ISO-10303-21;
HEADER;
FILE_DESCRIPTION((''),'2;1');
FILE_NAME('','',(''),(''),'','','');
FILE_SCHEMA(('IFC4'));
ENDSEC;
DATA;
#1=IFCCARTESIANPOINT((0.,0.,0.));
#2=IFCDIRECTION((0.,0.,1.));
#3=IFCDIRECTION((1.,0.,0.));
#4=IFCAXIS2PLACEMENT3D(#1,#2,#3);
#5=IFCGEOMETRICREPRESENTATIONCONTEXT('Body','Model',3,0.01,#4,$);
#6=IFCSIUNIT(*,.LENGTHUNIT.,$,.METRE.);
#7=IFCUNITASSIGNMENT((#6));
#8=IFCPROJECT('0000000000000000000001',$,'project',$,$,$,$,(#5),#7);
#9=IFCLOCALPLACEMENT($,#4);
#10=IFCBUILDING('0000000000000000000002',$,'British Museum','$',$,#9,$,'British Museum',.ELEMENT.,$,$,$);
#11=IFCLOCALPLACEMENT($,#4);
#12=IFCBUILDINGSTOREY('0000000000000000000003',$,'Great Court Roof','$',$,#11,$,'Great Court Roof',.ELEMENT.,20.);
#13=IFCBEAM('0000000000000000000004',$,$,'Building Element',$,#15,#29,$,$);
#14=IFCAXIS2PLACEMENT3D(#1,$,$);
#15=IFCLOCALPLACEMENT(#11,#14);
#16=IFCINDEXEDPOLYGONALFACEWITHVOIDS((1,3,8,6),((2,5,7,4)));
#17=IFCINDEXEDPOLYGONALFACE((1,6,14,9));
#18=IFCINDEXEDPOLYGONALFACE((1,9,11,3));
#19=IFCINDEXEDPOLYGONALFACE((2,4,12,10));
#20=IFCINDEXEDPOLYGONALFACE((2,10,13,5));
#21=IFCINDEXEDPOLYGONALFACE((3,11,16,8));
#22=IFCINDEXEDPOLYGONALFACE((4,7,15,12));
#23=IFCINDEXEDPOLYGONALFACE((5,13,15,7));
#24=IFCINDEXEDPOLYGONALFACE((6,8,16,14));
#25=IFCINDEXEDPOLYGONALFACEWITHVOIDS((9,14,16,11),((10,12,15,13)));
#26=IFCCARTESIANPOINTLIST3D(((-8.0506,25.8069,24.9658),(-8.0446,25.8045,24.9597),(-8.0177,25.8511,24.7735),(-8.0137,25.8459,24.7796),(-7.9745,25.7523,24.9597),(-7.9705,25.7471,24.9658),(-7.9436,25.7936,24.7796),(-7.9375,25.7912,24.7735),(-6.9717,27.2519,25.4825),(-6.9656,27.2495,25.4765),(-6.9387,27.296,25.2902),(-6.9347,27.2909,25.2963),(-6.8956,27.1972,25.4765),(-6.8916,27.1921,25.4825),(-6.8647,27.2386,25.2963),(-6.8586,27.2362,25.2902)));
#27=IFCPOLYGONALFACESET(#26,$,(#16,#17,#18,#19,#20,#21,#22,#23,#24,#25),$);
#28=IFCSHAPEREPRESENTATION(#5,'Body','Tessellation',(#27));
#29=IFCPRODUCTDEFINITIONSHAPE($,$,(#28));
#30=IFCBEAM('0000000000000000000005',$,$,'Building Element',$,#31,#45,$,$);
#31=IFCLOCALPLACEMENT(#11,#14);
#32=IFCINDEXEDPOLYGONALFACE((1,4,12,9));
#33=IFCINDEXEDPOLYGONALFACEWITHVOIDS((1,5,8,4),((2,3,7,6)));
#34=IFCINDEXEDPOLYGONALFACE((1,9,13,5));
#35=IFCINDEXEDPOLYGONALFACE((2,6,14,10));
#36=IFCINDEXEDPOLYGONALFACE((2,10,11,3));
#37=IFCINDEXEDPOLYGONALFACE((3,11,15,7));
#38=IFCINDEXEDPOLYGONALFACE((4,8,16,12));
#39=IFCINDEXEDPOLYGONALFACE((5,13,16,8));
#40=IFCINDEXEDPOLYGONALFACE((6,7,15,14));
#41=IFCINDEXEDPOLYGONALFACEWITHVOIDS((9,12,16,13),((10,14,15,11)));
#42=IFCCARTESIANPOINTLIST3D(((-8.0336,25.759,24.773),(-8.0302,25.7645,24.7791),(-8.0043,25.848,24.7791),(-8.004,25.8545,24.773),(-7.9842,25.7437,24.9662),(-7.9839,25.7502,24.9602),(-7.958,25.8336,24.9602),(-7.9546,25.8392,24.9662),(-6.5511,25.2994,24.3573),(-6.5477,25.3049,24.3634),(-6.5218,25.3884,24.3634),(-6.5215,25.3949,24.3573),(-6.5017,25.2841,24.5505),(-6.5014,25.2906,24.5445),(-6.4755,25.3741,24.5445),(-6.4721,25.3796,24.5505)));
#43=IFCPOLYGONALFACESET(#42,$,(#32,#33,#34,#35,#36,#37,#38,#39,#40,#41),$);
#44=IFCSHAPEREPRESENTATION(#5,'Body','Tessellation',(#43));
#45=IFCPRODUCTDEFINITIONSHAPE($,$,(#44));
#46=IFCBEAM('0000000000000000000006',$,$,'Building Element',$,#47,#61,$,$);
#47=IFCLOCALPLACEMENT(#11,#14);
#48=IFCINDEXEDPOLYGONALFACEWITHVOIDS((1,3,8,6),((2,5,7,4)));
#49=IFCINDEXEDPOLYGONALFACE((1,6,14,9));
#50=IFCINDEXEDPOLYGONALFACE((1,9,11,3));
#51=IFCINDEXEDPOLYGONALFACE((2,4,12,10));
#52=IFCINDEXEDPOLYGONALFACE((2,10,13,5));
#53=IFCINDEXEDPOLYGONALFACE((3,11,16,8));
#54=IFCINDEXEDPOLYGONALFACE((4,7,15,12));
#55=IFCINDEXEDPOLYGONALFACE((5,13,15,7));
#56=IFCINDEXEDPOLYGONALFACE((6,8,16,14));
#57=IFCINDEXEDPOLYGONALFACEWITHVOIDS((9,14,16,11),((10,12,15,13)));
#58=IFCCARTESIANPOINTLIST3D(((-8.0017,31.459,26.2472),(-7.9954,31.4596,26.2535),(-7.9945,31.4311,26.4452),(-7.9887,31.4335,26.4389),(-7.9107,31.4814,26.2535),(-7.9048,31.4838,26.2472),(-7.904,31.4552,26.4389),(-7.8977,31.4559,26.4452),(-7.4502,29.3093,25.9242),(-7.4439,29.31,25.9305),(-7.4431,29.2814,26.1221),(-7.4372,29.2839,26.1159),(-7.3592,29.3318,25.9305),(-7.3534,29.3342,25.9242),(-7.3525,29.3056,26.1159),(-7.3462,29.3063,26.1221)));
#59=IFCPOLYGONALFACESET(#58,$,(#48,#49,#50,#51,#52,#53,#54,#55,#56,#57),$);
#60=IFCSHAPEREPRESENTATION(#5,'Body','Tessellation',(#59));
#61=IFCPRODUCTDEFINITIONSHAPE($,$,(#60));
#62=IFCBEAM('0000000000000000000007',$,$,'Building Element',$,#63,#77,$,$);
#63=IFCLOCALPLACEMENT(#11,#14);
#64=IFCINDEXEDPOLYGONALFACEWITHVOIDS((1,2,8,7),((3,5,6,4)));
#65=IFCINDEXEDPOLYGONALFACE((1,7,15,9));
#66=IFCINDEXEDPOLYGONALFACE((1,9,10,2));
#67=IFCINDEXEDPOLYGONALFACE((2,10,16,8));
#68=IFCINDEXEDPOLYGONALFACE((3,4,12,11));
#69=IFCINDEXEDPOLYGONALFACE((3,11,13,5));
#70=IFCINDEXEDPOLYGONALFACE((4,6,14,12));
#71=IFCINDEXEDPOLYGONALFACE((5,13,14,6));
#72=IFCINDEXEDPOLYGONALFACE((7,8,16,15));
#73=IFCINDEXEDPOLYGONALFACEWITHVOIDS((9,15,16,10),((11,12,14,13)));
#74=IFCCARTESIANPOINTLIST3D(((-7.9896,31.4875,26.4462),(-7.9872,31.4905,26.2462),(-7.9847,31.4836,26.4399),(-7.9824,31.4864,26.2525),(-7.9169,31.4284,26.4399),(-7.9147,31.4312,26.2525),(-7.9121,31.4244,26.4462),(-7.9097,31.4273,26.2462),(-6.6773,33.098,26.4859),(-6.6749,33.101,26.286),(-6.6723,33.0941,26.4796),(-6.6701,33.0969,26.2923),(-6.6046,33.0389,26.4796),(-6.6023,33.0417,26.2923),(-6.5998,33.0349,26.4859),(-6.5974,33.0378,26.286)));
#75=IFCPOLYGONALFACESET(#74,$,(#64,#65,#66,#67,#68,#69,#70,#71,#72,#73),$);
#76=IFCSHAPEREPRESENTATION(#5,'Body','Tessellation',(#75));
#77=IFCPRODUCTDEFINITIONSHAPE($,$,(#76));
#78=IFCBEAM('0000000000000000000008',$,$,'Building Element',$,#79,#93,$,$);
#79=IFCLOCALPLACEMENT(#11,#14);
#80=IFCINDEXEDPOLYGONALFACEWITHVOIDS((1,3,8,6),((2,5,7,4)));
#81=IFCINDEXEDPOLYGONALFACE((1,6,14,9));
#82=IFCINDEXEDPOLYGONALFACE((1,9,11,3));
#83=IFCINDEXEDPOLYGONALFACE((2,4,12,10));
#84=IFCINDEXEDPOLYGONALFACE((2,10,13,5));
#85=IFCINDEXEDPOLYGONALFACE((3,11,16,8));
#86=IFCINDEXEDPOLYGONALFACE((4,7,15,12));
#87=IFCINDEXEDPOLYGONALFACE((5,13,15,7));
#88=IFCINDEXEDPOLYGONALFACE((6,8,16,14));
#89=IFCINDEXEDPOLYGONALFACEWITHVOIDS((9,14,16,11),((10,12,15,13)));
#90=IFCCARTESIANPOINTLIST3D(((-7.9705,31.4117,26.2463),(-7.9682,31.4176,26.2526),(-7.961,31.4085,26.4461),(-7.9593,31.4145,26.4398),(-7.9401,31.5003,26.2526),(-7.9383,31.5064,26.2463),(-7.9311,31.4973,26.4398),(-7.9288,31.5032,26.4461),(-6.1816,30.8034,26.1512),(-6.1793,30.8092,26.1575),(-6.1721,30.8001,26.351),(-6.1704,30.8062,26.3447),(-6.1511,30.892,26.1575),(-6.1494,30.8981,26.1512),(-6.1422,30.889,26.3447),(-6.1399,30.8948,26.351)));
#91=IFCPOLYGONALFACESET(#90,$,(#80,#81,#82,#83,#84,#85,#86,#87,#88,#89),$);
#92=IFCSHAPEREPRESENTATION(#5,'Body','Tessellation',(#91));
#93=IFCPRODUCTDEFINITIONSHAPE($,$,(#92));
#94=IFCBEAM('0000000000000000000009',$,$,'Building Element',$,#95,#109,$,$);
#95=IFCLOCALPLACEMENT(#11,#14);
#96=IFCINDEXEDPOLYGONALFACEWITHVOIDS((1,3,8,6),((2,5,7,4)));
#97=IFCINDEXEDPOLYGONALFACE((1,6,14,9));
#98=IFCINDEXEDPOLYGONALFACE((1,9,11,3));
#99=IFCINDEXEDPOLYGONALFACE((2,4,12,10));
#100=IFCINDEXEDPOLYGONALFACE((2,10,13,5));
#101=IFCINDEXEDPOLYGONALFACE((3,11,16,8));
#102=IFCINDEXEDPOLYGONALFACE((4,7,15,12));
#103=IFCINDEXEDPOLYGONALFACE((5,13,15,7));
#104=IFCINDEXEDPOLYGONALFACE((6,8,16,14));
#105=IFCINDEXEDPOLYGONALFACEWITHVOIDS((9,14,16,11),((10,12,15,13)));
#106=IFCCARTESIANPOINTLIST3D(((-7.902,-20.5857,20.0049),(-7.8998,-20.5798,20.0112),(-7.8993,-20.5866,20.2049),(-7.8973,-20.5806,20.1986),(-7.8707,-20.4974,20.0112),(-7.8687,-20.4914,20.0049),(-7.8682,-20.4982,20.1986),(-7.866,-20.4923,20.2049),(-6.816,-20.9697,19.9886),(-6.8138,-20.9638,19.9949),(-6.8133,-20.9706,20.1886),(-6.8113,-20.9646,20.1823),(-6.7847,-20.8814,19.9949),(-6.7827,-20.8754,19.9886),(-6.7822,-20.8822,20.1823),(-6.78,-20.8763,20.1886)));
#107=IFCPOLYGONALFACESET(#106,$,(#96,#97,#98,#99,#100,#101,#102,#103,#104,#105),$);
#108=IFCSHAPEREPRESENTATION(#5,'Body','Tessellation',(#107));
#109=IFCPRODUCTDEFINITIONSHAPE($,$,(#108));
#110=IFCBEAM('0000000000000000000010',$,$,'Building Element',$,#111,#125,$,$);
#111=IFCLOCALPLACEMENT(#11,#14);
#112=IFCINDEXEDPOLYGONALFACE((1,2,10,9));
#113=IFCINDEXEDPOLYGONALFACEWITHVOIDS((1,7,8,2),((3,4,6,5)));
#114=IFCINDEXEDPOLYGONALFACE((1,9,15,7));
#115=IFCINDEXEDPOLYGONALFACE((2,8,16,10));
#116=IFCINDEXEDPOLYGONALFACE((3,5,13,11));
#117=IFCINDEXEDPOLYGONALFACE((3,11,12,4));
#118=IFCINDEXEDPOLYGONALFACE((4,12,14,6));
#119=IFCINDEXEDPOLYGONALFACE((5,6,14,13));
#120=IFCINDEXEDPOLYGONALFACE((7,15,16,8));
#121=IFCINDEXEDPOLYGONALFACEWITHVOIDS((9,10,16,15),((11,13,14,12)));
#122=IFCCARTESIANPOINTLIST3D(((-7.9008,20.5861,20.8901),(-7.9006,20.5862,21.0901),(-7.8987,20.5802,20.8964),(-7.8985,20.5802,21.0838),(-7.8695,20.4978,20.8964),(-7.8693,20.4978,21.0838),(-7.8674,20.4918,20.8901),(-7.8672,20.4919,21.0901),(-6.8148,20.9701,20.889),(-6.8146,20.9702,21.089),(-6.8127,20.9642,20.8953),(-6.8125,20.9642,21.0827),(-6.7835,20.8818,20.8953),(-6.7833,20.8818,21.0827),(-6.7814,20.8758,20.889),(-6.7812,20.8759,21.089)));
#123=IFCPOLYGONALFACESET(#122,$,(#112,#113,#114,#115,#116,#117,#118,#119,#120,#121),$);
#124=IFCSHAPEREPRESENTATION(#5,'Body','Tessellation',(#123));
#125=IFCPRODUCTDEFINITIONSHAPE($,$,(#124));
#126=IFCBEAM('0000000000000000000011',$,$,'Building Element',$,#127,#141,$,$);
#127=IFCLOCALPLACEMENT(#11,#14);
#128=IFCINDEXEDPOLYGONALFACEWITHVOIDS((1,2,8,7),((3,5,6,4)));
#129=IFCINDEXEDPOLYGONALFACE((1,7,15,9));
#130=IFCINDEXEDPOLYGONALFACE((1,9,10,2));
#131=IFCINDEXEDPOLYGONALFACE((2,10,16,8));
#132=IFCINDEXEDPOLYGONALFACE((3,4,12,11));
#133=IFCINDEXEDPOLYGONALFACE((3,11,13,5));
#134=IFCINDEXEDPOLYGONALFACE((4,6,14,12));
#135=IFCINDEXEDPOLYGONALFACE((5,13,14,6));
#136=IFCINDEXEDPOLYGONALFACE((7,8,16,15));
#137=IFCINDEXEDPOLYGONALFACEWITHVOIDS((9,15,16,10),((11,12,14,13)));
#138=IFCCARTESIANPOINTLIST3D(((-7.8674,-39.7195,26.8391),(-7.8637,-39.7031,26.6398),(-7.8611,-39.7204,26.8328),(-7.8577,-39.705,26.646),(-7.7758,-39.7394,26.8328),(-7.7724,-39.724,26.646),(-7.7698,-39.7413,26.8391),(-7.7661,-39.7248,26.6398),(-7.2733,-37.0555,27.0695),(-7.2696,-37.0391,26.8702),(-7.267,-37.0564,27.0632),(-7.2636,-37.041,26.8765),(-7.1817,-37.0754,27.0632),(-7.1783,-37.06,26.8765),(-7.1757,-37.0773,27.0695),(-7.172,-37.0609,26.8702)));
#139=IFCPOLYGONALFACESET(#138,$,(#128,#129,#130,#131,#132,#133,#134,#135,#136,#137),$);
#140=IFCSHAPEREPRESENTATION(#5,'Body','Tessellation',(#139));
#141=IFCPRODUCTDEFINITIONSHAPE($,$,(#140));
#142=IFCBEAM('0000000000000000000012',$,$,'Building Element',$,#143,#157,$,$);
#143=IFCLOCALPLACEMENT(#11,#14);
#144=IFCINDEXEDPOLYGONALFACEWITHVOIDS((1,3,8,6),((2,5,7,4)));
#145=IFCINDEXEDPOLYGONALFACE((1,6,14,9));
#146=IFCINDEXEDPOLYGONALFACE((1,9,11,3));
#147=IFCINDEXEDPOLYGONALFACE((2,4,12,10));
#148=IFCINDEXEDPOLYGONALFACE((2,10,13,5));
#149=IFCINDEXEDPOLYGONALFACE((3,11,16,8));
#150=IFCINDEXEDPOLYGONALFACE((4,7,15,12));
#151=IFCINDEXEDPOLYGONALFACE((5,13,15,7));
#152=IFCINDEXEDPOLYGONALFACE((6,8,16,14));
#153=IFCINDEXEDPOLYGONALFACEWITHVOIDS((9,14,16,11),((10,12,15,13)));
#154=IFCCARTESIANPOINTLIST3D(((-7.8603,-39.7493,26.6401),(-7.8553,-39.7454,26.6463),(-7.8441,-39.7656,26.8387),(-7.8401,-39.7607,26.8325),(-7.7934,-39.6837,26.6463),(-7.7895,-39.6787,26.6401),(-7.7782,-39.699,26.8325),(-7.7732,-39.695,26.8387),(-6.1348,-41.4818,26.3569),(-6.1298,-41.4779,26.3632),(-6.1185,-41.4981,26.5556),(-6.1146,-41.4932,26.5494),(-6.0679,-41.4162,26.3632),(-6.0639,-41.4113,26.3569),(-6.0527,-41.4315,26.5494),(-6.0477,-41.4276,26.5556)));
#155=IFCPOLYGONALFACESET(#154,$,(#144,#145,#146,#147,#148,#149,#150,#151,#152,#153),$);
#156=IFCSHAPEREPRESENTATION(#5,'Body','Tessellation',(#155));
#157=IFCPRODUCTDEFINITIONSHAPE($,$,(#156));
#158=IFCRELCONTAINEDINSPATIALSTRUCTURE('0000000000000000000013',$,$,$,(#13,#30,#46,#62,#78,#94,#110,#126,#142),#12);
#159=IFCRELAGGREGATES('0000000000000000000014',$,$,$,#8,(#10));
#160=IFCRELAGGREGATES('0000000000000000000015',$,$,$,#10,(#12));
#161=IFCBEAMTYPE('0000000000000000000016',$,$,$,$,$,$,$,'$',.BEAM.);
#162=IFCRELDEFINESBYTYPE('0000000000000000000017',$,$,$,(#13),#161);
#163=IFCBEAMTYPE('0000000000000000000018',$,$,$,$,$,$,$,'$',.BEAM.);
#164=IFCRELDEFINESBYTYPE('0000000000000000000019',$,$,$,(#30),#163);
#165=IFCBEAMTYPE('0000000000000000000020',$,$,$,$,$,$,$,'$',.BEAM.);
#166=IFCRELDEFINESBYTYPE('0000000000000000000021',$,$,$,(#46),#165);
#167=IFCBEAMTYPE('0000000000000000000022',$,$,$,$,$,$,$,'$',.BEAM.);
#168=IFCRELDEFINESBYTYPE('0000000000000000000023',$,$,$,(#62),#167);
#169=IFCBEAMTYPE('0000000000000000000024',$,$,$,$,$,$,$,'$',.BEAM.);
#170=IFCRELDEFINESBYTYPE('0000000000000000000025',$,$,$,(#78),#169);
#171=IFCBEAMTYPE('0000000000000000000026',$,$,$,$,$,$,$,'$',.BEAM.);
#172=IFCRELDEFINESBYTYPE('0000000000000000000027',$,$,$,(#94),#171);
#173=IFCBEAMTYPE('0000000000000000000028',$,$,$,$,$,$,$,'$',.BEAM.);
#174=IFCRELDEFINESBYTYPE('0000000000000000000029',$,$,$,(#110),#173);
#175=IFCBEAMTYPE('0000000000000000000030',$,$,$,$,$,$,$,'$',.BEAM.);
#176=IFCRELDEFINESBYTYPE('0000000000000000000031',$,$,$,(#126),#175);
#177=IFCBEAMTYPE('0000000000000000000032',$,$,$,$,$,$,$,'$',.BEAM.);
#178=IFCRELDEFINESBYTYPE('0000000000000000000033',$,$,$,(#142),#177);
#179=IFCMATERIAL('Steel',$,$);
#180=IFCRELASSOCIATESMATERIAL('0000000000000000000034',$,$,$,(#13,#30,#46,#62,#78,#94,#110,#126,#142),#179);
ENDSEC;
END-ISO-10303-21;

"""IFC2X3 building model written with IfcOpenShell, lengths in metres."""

from ifc_helpers import new_model, si_unit, frame, origin_with_axes, origin_2d, place, context, project, spatial, hollow_rectangle, extrude, material, type_object, element, save


model = new_model("IFC2X3")

# Units and contexts
model_context = context("Model", 3, precision=0.01, world=origin_with_axes(), identifier="Body")
ifc_project = project(units=[si_unit("LENGTHUNIT", "METRE")], contexts=[model_context])

# Building, storey
building_placement = place(None, origin_with_axes())
building = spatial("IfcBuilding", under=ifc_project, at=building_placement, Name="British Museum", Description="$", LongName="British Museum", CompositionType="ELEMENT")
storey_placement = place(None, origin_with_axes())
storey = spatial("IfcBuildingStorey", under=building, at=storey_placement, Name="Great Court Roof", Description="$", LongName="Great Court Roof", CompositionType="ELEMENT", Elevation=20.0)

# Beams
ifc_material = material(Name="Steel")
beam_type_1 = type_object("IfcBeamType", ElementType="$", PredefinedType="BEAM")
beam_1_placement = place(None, origin_with_axes())
element("IfcBeam", 1, at=beam_1_placement, inside=storey, type_object=beam_type_1, material=ifc_material, Description="Building Element", context=model_context, shape_type="SweptSolid", body=[
    extrude(hollow_rectangle(XDim=0.1, YDim=0.2, WallThickness=0.0063, InnerFilletRadius=0.0, OuterFilletRadius=0.0, at=origin_2d()), frame((-7.9941, 25.7991, 24.8696), z_axis=(0.575161, 0.770269, 0.275455), x_axis=(-0.801267, 0.598307, 0.0)), (0.0, 0.0, 1.0), 1.8759),
])
beam_type_2 = type_object("IfcBeamType", ElementType="$", PredefinedType="BEAM")
beam_2_placement = place(None, origin_with_axes())
element("IfcBeam", 2, at=beam_2_placement, inside=storey, type_object=beam_type_2, material=ifc_material, Description="Building Element", context=model_context, shape_type="SweptSolid", body=[
    extrude(hollow_rectangle(XDim=0.1, YDim=0.2, WallThickness=0.0063, InnerFilletRadius=0.0, OuterFilletRadius=0.0, at=origin_2d()), frame((-7.9941, 25.7991, 24.8696), z_axis=(0.922636, -0.286024, -0.258716), x_axis=(0.296105, 0.955155, 0.0)), (0.0, 0.0, 1.0), 1.6068),
])
beam_type_3 = type_object("IfcBeamType", ElementType="$", PredefinedType="BEAM")
beam_3_placement = place(None, origin_with_axes())
element("IfcBeam", 3, at=beam_3_placement, inside=storey, type_object=beam_type_3, material=ifc_material, Description="Building Element", context=model_context, shape_type="SweptSolid", body=[
    extrude(hollow_rectangle(XDim=0.1, YDim=0.2, WallThickness=0.0063, InnerFilletRadius=0.0, OuterFilletRadius=0.0, at=origin_2d()), frame((-7.9497, 31.4574, 26.3462), z_axis=(0.245904, -0.958533, -0.144035), x_axis=(0.968633, 0.248495, 0.0)), (0.0, 0.0, 1.0), 2.2426),
])
beam_type_4 = type_object("IfcBeamType", ElementType="$", PredefinedType="BEAM")
beam_4_placement = place(None, origin_with_axes())
element("IfcBeam", 4, at=beam_4_placement, inside=storey, type_object=beam_type_4, material=ifc_material, Description="Building Element", context=model_context, shape_type="SweptSolid", body=[
    extrude(hollow_rectangle(XDim=0.1, YDim=0.2, WallThickness=0.0063, InnerFilletRadius=0.0, OuterFilletRadius=0.0, at=origin_2d()), frame((-7.9497, 31.4574, 26.3462), z_axis=(0.631586, 0.77507, 0.019136), x_axis=(-0.775212, 0.631702, 0.0)), (0.0, 0.0, 1.0), 2.0779),
])
beam_type_5 = type_object("IfcBeamType", ElementType="$", PredefinedType="BEAM")
beam_5_placement = place(None, origin_with_axes())
element("IfcBeam", 5, at=beam_5_placement, inside=storey, type_object=beam_type_5, material=ifc_material, Description="Building Element", context=model_context, shape_type="SweptSolid", body=[
    extrude(hollow_rectangle(XDim=0.1, YDim=0.2, WallThickness=0.0063, InnerFilletRadius=0.0, OuterFilletRadius=0.0, at=origin_2d()), frame((-7.9497, 31.4574, 26.3462), z_axis=(0.945559, -0.321544, -0.050273), x_axis=(0.321951, 0.946756, 0.0)), (0.0, 0.0, 1.0), 1.8919),
])
beam_type_6 = type_object("IfcBeamType", ElementType="$", PredefinedType="BEAM")
beam_6_placement = place(None, origin_with_axes())
element("IfcBeam", 6, at=beam_6_placement, inside=storey, type_object=beam_type_6, material=ifc_material, Description="Building Element", context=model_context, shape_type="SweptSolid", body=[
    extrude(hollow_rectangle(XDim=0.1, YDim=0.2, WallThickness=0.0063, InnerFilletRadius=0.0, OuterFilletRadius=0.0, at=origin_2d()), frame((-7.884, -20.539, 20.1049), z_axis=(0.942703, -0.333332, -0.014167), x_axis=(0.333365, 0.942798, 0.0)), (0.0, 0.0, 1.0), 1.152),
])
beam_type_7 = type_object("IfcBeamType", ElementType="$", PredefinedType="BEAM")
beam_7_placement = place(None, origin_with_axes())
element("IfcBeam", 7, at=beam_7_placement, inside=storey, type_object=beam_type_7, material=ifc_material, Description="Building Element", context=model_context, shape_type="SweptSolid", body=[
    extrude(hollow_rectangle(XDim=0.1, YDim=0.2, WallThickness=0.0063, InnerFilletRadius=0.0, OuterFilletRadius=0.0, at=origin_2d()), frame((-7.884, 20.539, 20.9901), z_axis=(0.942797, 0.333365, -0.000967), x_axis=(-0.333365, 0.942798, 0.0)), (0.0, 0.0, 1.0), 1.1519),
])
beam_type_8 = type_object("IfcBeamType", ElementType="$", PredefinedType="BEAM")
beam_8_placement = place(None, origin_with_axes())
element("IfcBeam", 8, at=beam_8_placement, inside=storey, type_object=beam_type_8, material=ifc_material, Description="Building Element", context=model_context, shape_type="SweptSolid", body=[
    extrude(hollow_rectangle(XDim=0.1, YDim=0.2, WallThickness=0.0063, InnerFilletRadius=0.0, OuterFilletRadius=0.0, at=origin_2d()), frame((-7.8168, -39.7222, 26.7394), z_axis=(0.216898, 0.972561, 0.084138), x_axis=(-0.976022, 0.21767, 0.0)), (0.0, 0.0, 1.0), 2.7391),
])
beam_type_9 = type_object("IfcBeamType", ElementType="$", PredefinedType="BEAM")
beam_9_placement = place(None, origin_with_axes())
element("IfcBeam", 9, at=beam_9_placement, inside=storey, type_object=beam_type_9, material=ifc_material, Description="Building Element", context=model_context, shape_type="SweptSolid", body=[
    extrude(hollow_rectangle(XDim=0.1, YDim=0.2, WallThickness=0.0063, InnerFilletRadius=0.0, OuterFilletRadius=0.0, at=origin_2d()), frame((-7.8168, -39.7222, 26.7394), z_axis=(0.700991, -0.703834, -0.115019), x_axis=(0.708536, 0.705674, 0.0)), (0.0, 0.0, 1.0), 2.4616),
])

save(model, "model.ifc")
